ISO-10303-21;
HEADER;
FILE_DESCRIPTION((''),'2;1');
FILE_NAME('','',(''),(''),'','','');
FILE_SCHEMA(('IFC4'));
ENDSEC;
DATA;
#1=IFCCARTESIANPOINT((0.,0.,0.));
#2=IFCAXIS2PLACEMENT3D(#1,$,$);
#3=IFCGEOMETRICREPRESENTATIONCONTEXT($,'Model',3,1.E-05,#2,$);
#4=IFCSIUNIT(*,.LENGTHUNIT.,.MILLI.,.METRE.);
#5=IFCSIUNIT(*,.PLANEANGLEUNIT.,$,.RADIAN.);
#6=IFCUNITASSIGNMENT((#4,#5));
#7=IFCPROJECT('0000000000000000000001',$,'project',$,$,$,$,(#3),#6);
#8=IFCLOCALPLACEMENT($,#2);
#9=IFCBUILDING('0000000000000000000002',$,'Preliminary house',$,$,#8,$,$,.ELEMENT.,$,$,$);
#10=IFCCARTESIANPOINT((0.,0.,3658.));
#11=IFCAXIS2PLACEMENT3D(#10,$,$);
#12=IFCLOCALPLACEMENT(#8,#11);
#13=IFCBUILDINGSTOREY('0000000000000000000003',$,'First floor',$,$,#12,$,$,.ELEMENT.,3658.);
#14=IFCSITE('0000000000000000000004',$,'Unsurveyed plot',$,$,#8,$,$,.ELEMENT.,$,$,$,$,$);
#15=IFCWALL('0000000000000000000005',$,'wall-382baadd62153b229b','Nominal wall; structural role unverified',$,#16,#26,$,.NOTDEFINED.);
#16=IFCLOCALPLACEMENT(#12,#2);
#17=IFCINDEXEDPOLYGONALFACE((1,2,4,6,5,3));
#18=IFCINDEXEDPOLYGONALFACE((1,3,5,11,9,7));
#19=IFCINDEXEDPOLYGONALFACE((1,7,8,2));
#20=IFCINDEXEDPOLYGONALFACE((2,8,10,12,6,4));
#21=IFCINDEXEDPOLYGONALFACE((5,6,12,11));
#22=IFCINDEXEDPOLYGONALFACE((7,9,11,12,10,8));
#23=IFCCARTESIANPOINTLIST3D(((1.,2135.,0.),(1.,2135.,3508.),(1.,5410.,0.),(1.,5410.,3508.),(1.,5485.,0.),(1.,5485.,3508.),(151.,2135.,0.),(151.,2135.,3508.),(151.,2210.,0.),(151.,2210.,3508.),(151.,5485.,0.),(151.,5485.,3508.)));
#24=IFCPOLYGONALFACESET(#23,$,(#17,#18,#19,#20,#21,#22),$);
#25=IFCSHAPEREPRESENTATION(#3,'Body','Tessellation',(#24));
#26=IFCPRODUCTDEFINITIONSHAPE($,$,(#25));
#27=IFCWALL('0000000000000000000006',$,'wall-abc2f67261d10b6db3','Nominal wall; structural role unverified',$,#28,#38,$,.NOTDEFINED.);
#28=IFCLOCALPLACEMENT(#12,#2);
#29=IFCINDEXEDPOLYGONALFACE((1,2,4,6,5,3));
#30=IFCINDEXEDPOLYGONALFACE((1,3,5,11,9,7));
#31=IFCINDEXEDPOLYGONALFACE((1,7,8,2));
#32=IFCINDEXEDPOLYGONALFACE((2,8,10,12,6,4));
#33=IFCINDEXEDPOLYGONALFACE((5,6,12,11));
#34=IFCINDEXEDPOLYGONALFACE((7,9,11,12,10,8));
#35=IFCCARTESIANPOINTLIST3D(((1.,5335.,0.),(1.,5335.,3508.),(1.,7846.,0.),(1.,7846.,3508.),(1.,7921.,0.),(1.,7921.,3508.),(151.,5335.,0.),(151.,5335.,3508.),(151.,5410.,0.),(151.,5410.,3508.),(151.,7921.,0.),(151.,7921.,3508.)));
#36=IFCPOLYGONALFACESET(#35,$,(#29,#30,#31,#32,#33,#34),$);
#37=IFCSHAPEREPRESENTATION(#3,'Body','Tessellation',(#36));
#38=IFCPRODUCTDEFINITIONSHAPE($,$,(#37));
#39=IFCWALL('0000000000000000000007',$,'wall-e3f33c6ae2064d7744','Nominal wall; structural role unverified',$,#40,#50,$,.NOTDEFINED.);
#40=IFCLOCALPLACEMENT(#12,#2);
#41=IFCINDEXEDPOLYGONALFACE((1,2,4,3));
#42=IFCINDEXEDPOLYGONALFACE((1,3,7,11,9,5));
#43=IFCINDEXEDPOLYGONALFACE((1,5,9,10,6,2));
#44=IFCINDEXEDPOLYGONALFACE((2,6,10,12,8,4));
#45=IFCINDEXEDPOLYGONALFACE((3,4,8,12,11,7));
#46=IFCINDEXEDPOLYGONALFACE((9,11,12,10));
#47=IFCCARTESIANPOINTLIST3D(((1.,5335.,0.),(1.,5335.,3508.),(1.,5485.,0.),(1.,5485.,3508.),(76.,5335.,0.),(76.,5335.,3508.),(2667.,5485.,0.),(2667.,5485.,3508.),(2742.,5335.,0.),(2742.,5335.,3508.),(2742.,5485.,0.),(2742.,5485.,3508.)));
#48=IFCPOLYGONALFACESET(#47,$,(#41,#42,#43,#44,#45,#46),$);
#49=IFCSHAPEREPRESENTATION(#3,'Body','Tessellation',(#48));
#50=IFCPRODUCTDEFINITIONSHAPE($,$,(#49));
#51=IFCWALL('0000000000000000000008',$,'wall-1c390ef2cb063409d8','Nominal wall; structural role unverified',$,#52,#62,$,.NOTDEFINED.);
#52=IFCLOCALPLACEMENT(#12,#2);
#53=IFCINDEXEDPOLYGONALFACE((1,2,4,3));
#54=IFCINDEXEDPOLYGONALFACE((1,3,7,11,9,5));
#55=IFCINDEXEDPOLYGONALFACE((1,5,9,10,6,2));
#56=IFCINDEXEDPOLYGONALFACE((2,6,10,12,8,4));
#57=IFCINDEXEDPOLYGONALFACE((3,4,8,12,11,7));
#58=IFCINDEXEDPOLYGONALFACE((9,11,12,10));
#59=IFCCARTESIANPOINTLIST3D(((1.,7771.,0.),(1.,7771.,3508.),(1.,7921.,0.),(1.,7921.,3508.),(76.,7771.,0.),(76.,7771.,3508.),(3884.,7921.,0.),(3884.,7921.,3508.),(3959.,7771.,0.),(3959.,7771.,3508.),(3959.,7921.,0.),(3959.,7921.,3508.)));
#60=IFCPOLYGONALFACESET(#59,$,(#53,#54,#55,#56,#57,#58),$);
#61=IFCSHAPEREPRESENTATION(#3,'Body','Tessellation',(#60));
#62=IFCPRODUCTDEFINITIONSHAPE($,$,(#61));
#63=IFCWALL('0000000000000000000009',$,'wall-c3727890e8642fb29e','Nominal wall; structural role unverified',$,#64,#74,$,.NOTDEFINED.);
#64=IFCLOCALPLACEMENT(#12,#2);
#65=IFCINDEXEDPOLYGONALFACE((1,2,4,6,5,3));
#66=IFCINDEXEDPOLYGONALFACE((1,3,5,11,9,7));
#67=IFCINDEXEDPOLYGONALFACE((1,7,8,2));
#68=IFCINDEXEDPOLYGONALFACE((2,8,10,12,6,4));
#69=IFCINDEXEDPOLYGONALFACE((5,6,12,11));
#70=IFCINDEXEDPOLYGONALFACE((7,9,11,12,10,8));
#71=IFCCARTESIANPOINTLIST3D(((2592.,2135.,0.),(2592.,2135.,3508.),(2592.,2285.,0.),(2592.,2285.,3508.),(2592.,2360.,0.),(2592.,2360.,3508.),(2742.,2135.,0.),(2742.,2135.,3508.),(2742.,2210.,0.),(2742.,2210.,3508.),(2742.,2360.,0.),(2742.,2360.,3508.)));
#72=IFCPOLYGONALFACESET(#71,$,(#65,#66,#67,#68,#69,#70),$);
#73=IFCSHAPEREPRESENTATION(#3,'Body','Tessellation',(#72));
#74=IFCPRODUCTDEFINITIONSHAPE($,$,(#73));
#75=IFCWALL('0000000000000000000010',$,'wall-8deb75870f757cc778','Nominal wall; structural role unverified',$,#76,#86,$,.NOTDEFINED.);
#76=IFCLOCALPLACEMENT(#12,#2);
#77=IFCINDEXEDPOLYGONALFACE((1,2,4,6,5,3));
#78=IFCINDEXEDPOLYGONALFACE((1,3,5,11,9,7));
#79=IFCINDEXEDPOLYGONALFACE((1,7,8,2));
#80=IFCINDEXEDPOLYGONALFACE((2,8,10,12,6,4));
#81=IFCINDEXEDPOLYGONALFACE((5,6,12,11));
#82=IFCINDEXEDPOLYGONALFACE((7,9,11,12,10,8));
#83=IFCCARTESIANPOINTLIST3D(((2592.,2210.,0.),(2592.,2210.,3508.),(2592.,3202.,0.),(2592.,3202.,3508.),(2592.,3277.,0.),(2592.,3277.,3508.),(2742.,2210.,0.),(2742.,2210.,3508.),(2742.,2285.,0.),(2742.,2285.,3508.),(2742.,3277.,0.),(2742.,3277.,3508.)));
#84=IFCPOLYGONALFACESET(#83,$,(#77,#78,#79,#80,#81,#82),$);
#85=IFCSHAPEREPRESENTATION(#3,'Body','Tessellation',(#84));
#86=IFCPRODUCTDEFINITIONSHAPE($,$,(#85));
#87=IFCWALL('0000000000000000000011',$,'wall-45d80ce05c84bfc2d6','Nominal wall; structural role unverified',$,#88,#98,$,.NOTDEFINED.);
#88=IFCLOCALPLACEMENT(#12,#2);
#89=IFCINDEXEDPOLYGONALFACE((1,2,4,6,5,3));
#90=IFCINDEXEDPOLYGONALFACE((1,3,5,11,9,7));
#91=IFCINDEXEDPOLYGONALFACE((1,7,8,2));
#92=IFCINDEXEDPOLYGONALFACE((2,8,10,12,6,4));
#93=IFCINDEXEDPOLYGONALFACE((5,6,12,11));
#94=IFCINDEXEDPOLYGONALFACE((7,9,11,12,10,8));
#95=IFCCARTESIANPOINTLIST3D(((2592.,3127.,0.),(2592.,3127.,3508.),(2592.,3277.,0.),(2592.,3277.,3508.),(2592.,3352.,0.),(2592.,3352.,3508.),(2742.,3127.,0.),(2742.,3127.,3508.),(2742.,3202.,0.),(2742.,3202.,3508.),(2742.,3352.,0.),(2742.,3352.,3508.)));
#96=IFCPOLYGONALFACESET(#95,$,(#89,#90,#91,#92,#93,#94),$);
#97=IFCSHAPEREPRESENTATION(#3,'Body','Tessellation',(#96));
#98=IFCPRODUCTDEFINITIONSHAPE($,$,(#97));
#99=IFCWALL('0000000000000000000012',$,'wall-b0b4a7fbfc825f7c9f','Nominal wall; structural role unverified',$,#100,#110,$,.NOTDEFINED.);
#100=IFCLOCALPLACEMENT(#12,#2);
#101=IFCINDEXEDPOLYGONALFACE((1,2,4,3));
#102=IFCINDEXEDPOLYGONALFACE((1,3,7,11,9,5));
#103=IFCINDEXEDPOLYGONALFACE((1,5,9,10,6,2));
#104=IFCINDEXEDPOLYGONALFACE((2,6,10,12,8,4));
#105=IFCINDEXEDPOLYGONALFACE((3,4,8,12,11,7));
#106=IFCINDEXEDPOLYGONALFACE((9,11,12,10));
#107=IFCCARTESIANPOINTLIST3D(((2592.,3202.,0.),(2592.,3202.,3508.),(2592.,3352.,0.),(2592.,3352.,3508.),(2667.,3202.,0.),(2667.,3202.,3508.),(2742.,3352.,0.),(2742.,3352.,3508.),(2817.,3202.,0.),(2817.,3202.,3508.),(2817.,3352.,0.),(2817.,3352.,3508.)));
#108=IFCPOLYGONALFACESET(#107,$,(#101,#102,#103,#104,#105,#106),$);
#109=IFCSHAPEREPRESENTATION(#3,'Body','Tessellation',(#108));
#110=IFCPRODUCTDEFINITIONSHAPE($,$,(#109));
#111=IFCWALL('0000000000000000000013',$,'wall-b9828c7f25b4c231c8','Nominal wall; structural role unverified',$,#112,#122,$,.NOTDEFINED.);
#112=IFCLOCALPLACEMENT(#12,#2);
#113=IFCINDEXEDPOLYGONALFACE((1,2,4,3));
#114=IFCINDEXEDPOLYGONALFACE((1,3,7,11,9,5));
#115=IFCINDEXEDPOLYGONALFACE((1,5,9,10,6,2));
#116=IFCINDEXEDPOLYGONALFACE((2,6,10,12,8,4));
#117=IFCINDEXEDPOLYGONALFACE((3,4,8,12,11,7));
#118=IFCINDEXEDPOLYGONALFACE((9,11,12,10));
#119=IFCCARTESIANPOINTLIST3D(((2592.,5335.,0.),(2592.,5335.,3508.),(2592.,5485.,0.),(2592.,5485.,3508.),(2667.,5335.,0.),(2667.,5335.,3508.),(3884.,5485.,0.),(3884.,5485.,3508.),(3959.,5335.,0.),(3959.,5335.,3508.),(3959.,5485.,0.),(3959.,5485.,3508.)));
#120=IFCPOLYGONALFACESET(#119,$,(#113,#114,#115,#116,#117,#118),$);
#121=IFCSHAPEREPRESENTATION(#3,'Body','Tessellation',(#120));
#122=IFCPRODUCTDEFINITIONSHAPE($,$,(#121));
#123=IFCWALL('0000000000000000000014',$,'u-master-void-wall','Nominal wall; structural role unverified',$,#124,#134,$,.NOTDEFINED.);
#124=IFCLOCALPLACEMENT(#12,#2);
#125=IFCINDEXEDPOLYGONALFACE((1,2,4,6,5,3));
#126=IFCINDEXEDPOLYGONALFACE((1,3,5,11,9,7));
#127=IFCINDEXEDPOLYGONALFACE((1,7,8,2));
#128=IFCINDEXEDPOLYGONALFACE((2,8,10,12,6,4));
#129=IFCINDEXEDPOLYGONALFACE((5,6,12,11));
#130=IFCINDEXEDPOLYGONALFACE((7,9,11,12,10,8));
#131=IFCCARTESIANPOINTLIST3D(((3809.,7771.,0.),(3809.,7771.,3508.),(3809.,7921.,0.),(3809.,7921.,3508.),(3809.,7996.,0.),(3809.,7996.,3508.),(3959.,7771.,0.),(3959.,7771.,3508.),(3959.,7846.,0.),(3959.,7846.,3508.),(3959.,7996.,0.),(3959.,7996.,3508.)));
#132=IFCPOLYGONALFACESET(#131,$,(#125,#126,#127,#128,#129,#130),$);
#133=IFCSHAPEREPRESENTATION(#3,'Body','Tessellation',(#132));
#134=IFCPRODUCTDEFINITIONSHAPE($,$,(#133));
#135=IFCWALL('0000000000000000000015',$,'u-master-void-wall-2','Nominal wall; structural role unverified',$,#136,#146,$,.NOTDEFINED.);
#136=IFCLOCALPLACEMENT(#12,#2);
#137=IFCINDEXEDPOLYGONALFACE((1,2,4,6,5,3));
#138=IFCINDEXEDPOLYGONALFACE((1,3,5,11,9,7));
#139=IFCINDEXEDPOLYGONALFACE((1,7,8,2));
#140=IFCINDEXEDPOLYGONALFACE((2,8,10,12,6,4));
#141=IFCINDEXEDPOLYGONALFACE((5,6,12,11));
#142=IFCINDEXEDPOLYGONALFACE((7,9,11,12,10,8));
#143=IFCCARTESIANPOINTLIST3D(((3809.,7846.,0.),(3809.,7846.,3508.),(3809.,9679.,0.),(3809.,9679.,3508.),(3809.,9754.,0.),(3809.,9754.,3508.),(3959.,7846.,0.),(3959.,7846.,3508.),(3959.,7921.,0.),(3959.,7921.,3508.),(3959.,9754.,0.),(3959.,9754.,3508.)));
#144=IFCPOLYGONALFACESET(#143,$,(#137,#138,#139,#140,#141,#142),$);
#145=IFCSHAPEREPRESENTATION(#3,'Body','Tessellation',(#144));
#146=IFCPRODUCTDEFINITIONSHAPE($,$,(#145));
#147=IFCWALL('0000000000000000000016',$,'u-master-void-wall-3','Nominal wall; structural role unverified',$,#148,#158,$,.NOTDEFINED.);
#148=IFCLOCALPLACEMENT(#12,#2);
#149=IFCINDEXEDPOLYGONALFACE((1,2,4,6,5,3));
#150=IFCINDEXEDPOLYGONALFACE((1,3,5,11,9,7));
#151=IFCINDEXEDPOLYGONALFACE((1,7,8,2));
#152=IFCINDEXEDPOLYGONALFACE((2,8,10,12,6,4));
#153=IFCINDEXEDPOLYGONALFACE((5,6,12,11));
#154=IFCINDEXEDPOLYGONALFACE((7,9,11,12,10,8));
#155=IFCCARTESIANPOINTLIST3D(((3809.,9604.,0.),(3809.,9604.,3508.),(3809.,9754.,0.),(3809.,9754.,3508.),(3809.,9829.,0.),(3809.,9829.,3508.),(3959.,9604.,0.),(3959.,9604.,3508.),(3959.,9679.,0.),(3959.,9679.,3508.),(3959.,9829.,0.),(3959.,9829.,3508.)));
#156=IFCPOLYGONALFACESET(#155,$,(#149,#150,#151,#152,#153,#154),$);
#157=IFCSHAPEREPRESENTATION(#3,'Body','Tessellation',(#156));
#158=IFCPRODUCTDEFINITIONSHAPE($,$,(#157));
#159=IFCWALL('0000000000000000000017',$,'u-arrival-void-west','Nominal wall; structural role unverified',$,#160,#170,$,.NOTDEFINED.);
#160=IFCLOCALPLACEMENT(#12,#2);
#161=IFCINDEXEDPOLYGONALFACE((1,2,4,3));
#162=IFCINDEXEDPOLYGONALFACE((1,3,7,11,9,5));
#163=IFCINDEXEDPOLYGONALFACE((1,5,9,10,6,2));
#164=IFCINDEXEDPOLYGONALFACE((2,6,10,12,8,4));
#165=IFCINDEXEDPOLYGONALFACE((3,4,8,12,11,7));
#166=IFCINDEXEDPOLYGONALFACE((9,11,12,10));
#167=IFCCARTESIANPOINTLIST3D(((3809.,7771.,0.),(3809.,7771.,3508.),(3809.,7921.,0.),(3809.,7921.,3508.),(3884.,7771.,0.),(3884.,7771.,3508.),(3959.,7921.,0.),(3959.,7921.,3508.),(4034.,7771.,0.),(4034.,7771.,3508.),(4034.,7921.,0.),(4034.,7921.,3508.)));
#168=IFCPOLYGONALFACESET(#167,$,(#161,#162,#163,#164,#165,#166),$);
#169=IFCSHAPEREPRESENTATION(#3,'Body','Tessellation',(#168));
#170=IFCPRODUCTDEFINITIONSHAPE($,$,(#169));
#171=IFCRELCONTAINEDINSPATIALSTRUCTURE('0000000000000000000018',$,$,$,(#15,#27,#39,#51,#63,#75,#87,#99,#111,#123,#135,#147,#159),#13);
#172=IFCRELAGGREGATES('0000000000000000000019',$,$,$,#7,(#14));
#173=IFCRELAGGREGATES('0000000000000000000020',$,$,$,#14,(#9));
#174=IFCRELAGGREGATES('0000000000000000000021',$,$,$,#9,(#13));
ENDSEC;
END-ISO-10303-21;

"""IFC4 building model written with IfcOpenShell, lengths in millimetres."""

from ifc_helpers import new_model, si_unit, frame, origin, place, context, project, spatial, polyline, outline, extrude, element, save


model = new_model("IFC4")

# Units and contexts
model_context = context("Model", 3, precision=1e-05, world=origin())
ifc_project = project(units=[si_unit("LENGTHUNIT", "METRE", prefix="MILLI"), si_unit("PLANEANGLEUNIT", "RADIAN")], contexts=[model_context])

# Site, building, storey
placement_1 = place(None, origin())
site = spatial("IfcSite", under=ifc_project, at=placement_1, Name="Unsurveyed plot", CompositionType="ELEMENT")
building = spatial("IfcBuilding", under=site, at=placement_1, Name="Preliminary house", CompositionType="ELEMENT")
placement_2 = place(placement_1, frame((0.0, 0.0, 3658.0)))
storey = spatial("IfcBuildingStorey", under=building, at=placement_2, Name="First floor", CompositionType="ELEMENT", Elevation=3658.0)

# Wall
element("IfcWall", 1, at=placement_2, inside=storey, Name="wall-382baadd62153b229b", Description="Nominal wall; structural role unverified", PredefinedType="NOTDEFINED", context=model_context, shape_type="SweptSolid", body=[
    extrude(outline(polyline([(1.0, 5410.0), (1.0, 5485.0), (151.0, 5485.0), (151.0, 2210.0), (151.0, 2135.0), (1.0, 2135.0), (1.0, 5410.0)])), origin(), (0.0, 0.0, 1.0), 3508.0),
])

# Walls
element("IfcWall", 2, at=placement_2, inside=storey, Name="wall-abc2f67261d10b6db3", Description="Nominal wall; structural role unverified", PredefinedType="NOTDEFINED", context=model_context, shape_type="SweptSolid", body=[
    extrude(outline(polyline([(1.0, 7846.0), (1.0, 7921.0), (151.0, 7921.0), (151.0, 5410.0), (151.0, 5335.0), (1.0, 5335.0), (1.0, 7846.0)])), origin(), (0.0, 0.0, 1.0), 3508.0),
])
element("IfcWall", 3, at=placement_2, inside=storey, Name="wall-e3f33c6ae2064d7744", Description="Nominal wall; structural role unverified", PredefinedType="NOTDEFINED", context=model_context, shape_type="SweptSolid", body=[
    extrude(outline(polyline([(2667.0, 5485.0), (2742.0, 5485.0), (2742.0, 5335.0), (76.0, 5335.0), (1.0, 5335.0), (1.0, 5485.0), (2667.0, 5485.0)])), origin(), (0.0, 0.0, 1.0), 3508.0),
])

# Wall
element("IfcWall", 4, at=placement_2, inside=storey, Name="wall-1c390ef2cb063409d8", Description="Nominal wall; structural role unverified", PredefinedType="NOTDEFINED", context=model_context, shape_type="SweptSolid", body=[
    extrude(outline(polyline([(3884.0, 7921.0), (3959.0, 7921.0), (3959.0, 7771.0), (76.0, 7771.0), (1.0, 7771.0), (1.0, 7921.0), (3884.0, 7921.0)])), origin(), (0.0, 0.0, 1.0), 3508.0),
])

# Walls
element("IfcWall", 5, at=placement_2, inside=storey, Name="wall-c3727890e8642fb29e", Description="Nominal wall; structural role unverified", PredefinedType="NOTDEFINED", context=model_context, shape_type="SweptSolid", body=[
    extrude(outline(polyline([(2592.0, 2285.0), (2592.0, 2360.0), (2742.0, 2360.0), (2742.0, 2210.0), (2742.0, 2135.0), (2592.0, 2135.0), (2592.0, 2285.0)])), origin(), (0.0, 0.0, 1.0), 3508.0),
])
element("IfcWall", 6, at=placement_2, inside=storey, Name="wall-8deb75870f757cc778", Description="Nominal wall; structural role unverified", PredefinedType="NOTDEFINED", context=model_context, shape_type="SweptSolid", body=[
    extrude(outline(polyline([(2592.0, 3202.0), (2592.0, 3277.0), (2742.0, 3277.0), (2742.0, 2285.0), (2742.0, 2210.0), (2592.0, 2210.0), (2592.0, 3202.0)])), origin(), (0.0, 0.0, 1.0), 3508.0),
])
element("IfcWall", 7, at=placement_2, inside=storey, Name="wall-45d80ce05c84bfc2d6", Description="Nominal wall; structural role unverified", PredefinedType="NOTDEFINED", context=model_context, shape_type="SweptSolid", body=[
    extrude(outline(polyline([(2592.0, 3277.0), (2592.0, 3352.0), (2742.0, 3352.0), (2742.0, 3202.0), (2742.0, 3127.0), (2592.0, 3127.0), (2592.0, 3277.0)])), origin(), (0.0, 0.0, 1.0), 3508.0),
])

# Wall
element("IfcWall", 8, at=placement_2, inside=storey, Name="wall-b0b4a7fbfc825f7c9f", Description="Nominal wall; structural role unverified", PredefinedType="NOTDEFINED", context=model_context, shape_type="SweptSolid", body=[
    extrude(outline(polyline([(2742.0, 3352.0), (2817.0, 3352.0), (2817.0, 3202.0), (2667.0, 3202.0), (2592.0, 3202.0), (2592.0, 3352.0), (2742.0, 3352.0)])), origin(), (0.0, 0.0, 1.0), 3508.0),
])

# Wall
element("IfcWall", 9, at=placement_2, inside=storey, Name="wall-b9828c7f25b4c231c8", Description="Nominal wall; structural role unverified", PredefinedType="NOTDEFINED", context=model_context, shape_type="SweptSolid", body=[
    extrude(outline(polyline([(3884.0, 5485.0), (3959.0, 5485.0), (3959.0, 5335.0), (2667.0, 5335.0), (2592.0, 5335.0), (2592.0, 5485.0), (3884.0, 5485.0)])), origin(), (0.0, 0.0, 1.0), 3508.0),
])

# Walls
element("IfcWall", 10, at=placement_2, inside=storey, Name="u-master-void-wall", Description="Nominal wall; structural role unverified", PredefinedType="NOTDEFINED", context=model_context, shape_type="SweptSolid", body=[
    extrude(outline(polyline([(3809.0, 7921.0), (3809.0, 7996.0), (3959.0, 7996.0), (3959.0, 7846.0), (3959.0, 7771.0), (3809.0, 7771.0), (3809.0, 7921.0)])), origin(), (0.0, 0.0, 1.0), 3508.0),
])
element("IfcWall", 11, at=placement_2, inside=storey, Name="u-master-void-wall-2", Description="Nominal wall; structural role unverified", PredefinedType="NOTDEFINED", context=model_context, shape_type="SweptSolid", body=[
    extrude(outline(polyline([(3809.0, 9679.0), (3809.0, 9754.0), (3959.0, 9754.0), (3959.0, 7921.0), (3959.0, 7846.0), (3809.0, 7846.0), (3809.0, 9679.0)])), origin(), (0.0, 0.0, 1.0), 3508.0),
])
element("IfcWall", 12, at=placement_2, inside=storey, Name="u-master-void-wall-3", Description="Nominal wall; structural role unverified", PredefinedType="NOTDEFINED", context=model_context, shape_type="SweptSolid", body=[
    extrude(outline(polyline([(3809.0, 9754.0), (3809.0, 9829.0), (3959.0, 9829.0), (3959.0, 9679.0), (3959.0, 9604.0), (3809.0, 9604.0), (3809.0, 9754.0)])), origin(), (0.0, 0.0, 1.0), 3508.0),
])
element("IfcWall", 13, at=placement_2, inside=storey, Name="u-arrival-void-west", Description="Nominal wall; structural role unverified", PredefinedType="NOTDEFINED", context=model_context, shape_type="SweptSolid", body=[
    extrude(outline(polyline([(3959.0, 7921.0), (4034.0, 7921.0), (4034.0, 7771.0), (3884.0, 7771.0), (3809.0, 7771.0), (3809.0, 7921.0), (3959.0, 7921.0)])), origin(), (0.0, 0.0, 1.0), 3508.0),
])

save(model, "model.ifc")
